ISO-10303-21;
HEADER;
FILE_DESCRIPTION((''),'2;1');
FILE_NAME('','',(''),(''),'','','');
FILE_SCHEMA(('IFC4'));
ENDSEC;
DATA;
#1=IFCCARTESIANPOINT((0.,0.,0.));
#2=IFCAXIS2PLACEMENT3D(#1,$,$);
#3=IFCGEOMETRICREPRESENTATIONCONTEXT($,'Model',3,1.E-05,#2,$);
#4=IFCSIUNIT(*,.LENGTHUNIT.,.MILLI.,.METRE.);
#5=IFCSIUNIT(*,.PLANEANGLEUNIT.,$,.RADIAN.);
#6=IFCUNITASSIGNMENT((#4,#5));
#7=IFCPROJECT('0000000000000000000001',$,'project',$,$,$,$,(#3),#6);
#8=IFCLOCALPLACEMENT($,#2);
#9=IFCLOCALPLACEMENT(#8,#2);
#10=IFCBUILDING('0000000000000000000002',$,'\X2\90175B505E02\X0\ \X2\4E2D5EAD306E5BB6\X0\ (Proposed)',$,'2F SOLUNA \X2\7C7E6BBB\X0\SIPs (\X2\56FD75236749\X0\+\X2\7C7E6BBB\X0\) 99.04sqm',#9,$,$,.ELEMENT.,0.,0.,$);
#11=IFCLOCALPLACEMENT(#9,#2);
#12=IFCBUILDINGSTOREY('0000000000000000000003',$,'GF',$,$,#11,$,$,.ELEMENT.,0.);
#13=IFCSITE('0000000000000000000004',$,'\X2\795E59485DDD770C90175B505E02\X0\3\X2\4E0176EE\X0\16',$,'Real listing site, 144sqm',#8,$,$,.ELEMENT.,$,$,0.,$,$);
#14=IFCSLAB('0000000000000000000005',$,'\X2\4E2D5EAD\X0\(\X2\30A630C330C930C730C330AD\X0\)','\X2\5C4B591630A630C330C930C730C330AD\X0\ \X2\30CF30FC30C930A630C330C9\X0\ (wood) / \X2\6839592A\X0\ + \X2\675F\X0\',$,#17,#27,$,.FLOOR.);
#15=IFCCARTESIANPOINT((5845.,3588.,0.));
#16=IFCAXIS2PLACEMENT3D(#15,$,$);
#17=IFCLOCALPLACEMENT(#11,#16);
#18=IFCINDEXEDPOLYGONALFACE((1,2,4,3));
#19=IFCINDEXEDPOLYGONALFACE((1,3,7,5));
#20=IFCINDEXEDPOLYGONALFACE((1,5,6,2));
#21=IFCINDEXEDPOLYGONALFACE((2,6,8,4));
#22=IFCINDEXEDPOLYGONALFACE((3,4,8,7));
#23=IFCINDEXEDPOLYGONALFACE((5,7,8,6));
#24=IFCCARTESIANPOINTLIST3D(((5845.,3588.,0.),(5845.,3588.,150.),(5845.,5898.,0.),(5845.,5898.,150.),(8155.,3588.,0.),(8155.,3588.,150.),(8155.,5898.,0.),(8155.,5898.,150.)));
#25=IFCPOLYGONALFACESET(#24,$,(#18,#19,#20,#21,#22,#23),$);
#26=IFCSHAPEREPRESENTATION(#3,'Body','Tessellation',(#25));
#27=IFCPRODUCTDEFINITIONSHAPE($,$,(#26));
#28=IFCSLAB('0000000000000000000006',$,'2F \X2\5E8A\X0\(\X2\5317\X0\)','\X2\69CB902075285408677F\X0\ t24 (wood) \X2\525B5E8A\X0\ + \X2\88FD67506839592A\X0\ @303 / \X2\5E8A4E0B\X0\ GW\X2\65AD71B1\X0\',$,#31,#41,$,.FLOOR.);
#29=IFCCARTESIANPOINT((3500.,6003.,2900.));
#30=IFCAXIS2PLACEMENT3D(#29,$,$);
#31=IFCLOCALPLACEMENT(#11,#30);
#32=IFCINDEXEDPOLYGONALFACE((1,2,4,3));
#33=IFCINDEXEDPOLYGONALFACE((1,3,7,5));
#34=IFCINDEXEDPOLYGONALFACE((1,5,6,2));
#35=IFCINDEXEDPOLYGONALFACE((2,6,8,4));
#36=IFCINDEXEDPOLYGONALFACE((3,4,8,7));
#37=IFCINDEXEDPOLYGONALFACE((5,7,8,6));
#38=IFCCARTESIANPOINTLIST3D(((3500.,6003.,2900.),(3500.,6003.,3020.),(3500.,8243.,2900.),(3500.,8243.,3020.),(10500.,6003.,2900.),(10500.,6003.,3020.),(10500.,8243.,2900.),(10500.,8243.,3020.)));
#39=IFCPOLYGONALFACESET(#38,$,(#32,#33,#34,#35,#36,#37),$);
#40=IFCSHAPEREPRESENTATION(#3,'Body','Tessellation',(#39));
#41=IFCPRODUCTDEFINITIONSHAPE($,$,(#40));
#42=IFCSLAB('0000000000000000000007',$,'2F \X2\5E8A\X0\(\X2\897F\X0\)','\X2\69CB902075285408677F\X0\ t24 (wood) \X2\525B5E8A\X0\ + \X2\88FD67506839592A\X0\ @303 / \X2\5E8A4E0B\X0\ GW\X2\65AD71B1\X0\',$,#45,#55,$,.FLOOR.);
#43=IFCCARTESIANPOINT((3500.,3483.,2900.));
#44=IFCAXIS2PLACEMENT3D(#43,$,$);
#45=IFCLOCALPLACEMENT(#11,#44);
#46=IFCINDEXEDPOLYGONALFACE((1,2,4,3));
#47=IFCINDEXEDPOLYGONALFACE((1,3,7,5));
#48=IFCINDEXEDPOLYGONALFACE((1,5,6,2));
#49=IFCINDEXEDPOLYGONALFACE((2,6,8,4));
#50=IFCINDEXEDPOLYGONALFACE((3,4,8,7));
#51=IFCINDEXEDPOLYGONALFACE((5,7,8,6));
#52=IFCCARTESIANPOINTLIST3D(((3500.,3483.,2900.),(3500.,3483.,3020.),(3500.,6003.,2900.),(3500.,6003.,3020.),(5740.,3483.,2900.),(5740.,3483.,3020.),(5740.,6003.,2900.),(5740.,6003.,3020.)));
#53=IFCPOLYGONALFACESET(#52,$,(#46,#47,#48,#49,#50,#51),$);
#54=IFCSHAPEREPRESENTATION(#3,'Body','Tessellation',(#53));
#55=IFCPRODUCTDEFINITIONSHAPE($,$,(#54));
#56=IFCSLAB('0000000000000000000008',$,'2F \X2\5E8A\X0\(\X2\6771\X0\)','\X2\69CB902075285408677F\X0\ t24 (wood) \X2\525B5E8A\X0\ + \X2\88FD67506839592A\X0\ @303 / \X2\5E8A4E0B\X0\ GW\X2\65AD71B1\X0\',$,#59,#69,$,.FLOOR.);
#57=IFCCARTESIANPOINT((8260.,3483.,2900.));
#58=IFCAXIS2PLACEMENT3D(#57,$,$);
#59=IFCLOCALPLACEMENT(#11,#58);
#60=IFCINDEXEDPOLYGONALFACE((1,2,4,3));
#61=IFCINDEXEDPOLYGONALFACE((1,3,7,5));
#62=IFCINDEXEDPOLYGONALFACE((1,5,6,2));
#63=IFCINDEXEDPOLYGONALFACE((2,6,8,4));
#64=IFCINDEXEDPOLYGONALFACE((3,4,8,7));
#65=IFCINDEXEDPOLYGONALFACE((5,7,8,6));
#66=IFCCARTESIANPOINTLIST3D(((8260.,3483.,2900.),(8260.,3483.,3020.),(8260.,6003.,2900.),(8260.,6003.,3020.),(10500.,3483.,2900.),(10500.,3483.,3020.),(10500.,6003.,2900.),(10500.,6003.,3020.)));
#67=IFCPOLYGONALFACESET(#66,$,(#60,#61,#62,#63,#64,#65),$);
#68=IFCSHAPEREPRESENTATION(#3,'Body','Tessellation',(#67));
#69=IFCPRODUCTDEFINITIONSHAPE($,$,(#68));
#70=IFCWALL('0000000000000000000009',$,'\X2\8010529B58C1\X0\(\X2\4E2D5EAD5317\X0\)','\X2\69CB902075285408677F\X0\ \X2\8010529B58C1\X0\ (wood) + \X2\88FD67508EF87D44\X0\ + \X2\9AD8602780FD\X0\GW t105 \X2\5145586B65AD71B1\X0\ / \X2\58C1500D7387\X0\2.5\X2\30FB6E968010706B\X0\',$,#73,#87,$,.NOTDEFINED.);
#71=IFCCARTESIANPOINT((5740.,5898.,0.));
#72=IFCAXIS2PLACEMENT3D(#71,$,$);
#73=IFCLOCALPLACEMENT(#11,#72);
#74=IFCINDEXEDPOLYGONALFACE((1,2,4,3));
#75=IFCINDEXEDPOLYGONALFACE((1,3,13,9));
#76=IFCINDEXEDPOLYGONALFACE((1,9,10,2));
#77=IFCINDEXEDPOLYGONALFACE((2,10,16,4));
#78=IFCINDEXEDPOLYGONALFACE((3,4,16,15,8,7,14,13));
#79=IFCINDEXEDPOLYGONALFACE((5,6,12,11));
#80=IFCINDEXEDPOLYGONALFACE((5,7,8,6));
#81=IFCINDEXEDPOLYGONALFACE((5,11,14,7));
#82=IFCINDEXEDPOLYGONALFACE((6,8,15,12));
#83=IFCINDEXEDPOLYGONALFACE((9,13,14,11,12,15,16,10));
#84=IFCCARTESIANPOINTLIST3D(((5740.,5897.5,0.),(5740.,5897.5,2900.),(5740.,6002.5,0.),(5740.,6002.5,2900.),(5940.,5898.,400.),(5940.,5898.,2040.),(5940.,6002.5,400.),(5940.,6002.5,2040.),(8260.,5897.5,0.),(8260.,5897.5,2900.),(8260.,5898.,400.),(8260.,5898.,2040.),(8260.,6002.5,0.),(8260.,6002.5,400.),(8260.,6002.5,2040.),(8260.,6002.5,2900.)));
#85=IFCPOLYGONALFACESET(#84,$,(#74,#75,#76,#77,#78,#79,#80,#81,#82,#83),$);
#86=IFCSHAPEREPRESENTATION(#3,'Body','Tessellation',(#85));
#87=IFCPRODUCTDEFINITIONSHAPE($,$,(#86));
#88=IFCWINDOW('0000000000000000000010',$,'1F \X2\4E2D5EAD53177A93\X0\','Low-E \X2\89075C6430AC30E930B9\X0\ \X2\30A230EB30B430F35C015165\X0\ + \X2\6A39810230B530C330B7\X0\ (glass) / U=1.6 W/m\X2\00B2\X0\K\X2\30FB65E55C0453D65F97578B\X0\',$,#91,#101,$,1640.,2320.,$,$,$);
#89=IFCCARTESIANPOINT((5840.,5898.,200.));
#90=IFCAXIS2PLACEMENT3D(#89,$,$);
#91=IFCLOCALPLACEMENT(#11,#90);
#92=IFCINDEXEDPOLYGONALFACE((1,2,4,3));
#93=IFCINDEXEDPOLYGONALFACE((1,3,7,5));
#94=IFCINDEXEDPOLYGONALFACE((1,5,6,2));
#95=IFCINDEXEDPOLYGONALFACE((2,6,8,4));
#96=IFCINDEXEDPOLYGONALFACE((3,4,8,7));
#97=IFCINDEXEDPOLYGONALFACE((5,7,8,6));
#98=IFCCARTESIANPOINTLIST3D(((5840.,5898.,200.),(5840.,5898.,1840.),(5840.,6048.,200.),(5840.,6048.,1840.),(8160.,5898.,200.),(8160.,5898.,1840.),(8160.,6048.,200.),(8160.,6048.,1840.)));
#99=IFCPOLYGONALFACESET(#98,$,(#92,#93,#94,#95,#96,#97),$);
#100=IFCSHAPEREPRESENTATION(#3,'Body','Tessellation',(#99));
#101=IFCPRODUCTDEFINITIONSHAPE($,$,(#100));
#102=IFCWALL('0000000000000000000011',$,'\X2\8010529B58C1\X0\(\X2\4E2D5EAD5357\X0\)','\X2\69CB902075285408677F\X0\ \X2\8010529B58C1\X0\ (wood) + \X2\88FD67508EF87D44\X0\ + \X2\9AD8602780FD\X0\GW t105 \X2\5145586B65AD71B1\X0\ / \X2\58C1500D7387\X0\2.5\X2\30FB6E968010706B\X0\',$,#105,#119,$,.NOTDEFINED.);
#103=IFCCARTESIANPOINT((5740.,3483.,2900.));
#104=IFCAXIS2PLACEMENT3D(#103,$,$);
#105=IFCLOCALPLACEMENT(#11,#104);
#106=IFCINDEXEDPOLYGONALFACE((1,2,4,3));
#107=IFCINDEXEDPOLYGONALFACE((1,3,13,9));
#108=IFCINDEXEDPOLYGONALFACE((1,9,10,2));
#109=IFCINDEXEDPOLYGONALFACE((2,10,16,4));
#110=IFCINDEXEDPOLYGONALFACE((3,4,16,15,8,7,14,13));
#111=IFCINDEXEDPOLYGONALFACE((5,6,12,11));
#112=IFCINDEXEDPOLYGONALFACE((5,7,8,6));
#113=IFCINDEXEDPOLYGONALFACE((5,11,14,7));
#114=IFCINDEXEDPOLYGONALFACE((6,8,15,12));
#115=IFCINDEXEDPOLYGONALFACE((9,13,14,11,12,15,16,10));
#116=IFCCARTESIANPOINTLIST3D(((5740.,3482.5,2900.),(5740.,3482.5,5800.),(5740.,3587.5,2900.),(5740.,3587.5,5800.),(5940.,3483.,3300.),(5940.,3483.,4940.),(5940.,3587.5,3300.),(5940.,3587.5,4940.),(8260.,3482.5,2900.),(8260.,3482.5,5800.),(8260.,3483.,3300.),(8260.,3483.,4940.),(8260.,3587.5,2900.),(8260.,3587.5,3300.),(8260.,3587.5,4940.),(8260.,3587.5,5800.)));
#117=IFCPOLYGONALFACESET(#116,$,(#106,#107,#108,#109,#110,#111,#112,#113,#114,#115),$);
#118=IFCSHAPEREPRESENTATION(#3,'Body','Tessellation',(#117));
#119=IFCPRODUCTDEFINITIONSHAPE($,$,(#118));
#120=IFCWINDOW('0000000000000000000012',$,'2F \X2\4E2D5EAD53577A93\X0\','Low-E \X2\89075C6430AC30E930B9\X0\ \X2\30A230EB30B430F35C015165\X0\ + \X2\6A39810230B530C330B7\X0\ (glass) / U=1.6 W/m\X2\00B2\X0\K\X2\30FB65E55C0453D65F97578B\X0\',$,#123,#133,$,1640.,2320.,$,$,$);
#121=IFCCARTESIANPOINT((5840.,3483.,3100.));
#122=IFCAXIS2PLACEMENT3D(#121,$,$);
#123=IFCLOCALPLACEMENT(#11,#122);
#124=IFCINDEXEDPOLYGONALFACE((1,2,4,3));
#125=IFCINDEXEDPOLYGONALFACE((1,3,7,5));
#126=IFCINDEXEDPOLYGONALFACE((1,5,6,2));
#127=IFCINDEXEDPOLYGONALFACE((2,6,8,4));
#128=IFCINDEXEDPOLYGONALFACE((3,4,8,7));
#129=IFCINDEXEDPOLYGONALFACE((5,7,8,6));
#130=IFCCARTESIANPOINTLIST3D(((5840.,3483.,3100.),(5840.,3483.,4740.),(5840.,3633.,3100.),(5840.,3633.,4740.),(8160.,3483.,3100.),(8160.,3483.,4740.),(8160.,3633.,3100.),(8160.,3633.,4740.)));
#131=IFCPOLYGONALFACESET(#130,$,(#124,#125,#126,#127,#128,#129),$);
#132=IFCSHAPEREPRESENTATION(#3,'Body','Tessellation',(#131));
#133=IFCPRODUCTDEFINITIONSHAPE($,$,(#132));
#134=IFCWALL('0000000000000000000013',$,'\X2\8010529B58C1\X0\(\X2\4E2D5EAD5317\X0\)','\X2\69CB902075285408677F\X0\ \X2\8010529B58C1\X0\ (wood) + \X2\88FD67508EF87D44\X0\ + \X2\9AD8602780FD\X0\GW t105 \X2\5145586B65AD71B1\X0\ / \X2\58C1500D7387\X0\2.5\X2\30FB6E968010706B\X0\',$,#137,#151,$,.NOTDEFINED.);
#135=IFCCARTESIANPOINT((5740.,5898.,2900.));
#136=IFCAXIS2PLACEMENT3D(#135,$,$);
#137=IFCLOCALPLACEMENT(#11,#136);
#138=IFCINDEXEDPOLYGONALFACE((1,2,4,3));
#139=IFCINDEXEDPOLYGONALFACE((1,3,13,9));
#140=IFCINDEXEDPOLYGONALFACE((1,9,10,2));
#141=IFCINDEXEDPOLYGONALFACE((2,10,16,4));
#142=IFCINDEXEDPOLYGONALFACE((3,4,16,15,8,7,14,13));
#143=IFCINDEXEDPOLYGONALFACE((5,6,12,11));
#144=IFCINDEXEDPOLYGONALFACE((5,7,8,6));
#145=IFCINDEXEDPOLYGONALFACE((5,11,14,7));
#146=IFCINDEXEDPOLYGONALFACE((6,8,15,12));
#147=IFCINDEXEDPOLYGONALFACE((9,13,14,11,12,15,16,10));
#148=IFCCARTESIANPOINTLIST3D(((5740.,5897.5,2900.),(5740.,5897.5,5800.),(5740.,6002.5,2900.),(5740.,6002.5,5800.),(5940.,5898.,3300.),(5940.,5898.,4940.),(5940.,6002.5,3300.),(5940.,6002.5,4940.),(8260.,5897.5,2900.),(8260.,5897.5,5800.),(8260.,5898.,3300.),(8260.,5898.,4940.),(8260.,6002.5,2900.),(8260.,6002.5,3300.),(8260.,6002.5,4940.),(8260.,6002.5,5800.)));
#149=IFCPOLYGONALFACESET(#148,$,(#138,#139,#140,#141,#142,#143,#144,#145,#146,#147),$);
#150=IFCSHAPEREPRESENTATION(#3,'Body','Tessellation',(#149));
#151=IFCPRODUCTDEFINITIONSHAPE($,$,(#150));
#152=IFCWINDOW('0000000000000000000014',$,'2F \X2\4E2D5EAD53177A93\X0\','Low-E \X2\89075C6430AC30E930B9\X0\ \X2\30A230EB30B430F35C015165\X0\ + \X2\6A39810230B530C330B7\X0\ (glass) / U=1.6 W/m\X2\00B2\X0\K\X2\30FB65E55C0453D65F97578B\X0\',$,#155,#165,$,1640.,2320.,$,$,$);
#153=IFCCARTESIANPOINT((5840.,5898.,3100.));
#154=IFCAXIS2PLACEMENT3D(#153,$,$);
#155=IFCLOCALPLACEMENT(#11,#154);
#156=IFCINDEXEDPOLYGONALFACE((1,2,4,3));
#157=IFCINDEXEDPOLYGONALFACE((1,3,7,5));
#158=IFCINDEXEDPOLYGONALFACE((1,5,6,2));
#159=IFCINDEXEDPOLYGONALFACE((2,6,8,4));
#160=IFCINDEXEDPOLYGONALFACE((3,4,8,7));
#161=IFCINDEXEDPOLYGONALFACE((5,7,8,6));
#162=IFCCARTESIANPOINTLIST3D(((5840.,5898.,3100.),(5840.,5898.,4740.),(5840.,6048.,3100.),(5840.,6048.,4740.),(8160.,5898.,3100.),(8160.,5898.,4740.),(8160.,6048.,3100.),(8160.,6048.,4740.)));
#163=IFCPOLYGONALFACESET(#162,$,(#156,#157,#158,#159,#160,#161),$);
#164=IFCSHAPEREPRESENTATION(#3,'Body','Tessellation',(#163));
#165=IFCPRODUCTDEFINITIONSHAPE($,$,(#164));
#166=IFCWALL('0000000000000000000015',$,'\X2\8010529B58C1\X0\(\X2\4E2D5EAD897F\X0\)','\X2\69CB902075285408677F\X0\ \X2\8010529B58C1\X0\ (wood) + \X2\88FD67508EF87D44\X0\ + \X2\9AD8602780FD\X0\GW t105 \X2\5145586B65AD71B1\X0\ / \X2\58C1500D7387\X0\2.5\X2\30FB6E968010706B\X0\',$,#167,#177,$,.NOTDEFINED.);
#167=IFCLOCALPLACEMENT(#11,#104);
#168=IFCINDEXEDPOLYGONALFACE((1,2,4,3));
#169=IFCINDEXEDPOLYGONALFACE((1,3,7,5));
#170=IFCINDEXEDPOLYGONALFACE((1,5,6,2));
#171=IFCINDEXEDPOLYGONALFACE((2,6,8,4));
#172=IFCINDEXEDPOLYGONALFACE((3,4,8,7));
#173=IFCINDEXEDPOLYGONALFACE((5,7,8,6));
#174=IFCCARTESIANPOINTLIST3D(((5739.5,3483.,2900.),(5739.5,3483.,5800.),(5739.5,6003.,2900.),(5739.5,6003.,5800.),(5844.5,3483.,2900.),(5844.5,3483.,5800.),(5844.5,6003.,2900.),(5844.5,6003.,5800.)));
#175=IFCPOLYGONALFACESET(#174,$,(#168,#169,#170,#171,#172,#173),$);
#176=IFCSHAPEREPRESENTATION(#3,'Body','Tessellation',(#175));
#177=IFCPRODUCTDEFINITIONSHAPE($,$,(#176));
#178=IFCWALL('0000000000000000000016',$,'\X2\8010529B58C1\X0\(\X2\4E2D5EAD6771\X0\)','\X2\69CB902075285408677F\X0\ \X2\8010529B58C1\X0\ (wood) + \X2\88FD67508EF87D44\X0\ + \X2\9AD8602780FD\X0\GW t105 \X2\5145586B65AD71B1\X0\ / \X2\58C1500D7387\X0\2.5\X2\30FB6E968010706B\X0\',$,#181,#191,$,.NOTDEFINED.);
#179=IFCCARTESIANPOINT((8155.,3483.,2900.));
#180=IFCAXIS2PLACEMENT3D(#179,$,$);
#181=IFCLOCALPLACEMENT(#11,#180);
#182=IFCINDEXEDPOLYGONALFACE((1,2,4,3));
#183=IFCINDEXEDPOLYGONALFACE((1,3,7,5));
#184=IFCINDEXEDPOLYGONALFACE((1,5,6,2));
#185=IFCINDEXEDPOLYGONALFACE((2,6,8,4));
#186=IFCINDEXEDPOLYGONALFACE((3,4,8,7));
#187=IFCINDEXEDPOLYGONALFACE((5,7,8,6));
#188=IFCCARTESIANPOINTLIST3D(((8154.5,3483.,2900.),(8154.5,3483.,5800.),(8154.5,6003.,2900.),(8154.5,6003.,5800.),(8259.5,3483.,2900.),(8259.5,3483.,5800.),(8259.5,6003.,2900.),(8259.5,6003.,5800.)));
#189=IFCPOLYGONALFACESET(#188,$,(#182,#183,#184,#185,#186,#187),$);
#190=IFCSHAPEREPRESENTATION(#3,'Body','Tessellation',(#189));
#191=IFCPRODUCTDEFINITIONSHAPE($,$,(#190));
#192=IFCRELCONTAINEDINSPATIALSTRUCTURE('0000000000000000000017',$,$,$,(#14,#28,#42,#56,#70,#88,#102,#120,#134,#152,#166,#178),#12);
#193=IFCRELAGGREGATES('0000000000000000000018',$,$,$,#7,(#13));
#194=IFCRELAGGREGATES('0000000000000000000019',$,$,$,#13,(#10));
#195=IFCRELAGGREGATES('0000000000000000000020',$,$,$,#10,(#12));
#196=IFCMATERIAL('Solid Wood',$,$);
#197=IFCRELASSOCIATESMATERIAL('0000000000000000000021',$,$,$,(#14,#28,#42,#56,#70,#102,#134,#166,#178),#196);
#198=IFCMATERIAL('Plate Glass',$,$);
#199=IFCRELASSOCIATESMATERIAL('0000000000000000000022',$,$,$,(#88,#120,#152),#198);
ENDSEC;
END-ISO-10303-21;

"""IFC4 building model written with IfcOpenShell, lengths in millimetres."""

from ifc_helpers import new_model, si_unit, frame, frame_2d, origin, place, context, project, spatial, rectangle, extrude, material, element, fill, save


model = new_model("IFC4")

# Units and contexts
model_context = context("Model", 3, precision=1e-05, world=origin())
ifc_project = project(units=[si_unit("LENGTHUNIT", "METRE", prefix="MILLI"), si_unit("PLANEANGLEUNIT", "RADIAN")], contexts=[model_context])

# Site, building, storey
site_placement = place(None, origin())
site = spatial("IfcSite", under=ifc_project, at=site_placement, Name="神奈川県逗子市3丁目16", ObjectType="Real listing site, 144sqm", CompositionType="ELEMENT", RefElevation=0.0)
building_placement = place(site_placement, origin())
building = spatial("IfcBuilding", under=site, at=building_placement, Name="逗子市 中庭の家 (Proposed)", ObjectType="2F SOLUNA 籾殻SIPs (国産杉+籾殻) 99.04sqm", CompositionType="ELEMENT", ElevationOfRefHeight=0.0, ElevationOfTerrain=0.0)
storey_placement = place(building_placement, origin())
storey = spatial("IfcBuildingStorey", under=building, at=storey_placement, Name="GF", CompositionType="ELEMENT", Elevation=0.0)

# Slabs
ifc_material_1 = material(Name="Solid Wood")
slab_1_placement = place(storey_placement, frame((5845.0, 3588.0, 0.0)))
element("IfcSlab", 1, at=slab_1_placement, inside=storey, material=ifc_material_1, Name="中庭(ウッドデッキ)", Description="屋外ウッドデッキ ハードウッド (wood) / 根太 + 束", PredefinedType="FLOOR", context=model_context, shape_type="SweptSolid", body=[
    extrude(rectangle(XDim=2310.0, YDim=2310.0, at=frame_2d((1155.0, 1155.0))), frame((5845.0, 3588.0, 0.0)), (0.0, 0.0, 1.0), 150.0),
])
slab_2_placement = place(storey_placement, frame((3500.0, 6003.0, 2900.0)))
element("IfcSlab", 2, at=slab_2_placement, inside=storey, material=ifc_material_1, Name="2F 床(北)", Description="構造用合板 t24 (wood) 剛床 + 製材根太 @303 / 床下 GW断熱", PredefinedType="FLOOR", context=model_context, shape_type="SweptSolid", body=[
    extrude(rectangle(XDim=7000.0, YDim=2240.0, at=frame_2d((3500.0, 1120.0))), frame((3500.0, 6003.0, 2900.0)), (0.0, 0.0, 1.0), 120.0),
])
slab_3_placement = place(storey_placement, frame((3500.0, 3483.0, 2900.0)))
element("IfcSlab", 3, at=slab_3_placement, inside=storey, material=ifc_material_1, Name="2F 床(西)", Description="構造用合板 t24 (wood) 剛床 + 製材根太 @303 / 床下 GW断熱", PredefinedType="FLOOR", context=model_context, shape_type="SweptSolid", body=[
    extrude(rectangle(XDim=2240.0, YDim=2520.0, at=frame_2d((1120.0, 1260.0))), frame((3500.0, 3483.0, 2900.0)), (0.0, 0.0, 1.0), 120.0),
])
slab_4_placement = place(storey_placement, frame((8260.0, 3483.0, 2900.0)))
element("IfcSlab", 4, at=slab_4_placement, inside=storey, material=ifc_material_1, Name="2F 床(東)", Description="構造用合板 t24 (wood) 剛床 + 製材根太 @303 / 床下 GW断熱", PredefinedType="FLOOR", context=model_context, shape_type="SweptSolid", body=[
    extrude(rectangle(XDim=2240.0, YDim=2520.0, at=frame_2d((1120.0, 1260.0))), frame((8260.0, 3483.0, 2900.0)), (0.0, 0.0, 1.0), 120.0),
])

# Wall, opening, window
wall_1_placement = place(storey_placement, frame((5740.0, 5898.0, 0.0)))
wall_1 = element("IfcWall", 5, at=wall_1_placement, inside=storey, material=ifc_material_1, Name="耐力壁(中庭北)", Description="構造用合板 耐力壁 (wood) + 製材軸組 + 高性能GW t105 充填断熱 / 壁倍率2.5・準耐火", PredefinedType="NOTDEFINED", context=model_context, shape_type="SweptSolid", body=[
    extrude(rectangle(XDim=2520.0, YDim=105.0, at=frame_2d((1260.0, 52.0))), frame((5740.0, 5898.0, 0.0)), (0.0, 0.0, 1.0), 2900.0),
])
opening_1_placement = place(storey_placement, frame((5840.0, 5898.0, 200.0)))
opening_1 = element("IfcOpeningElement", 6, at=opening_1_placement, cuts=wall_1, PredefinedType="NOTDEFINED", context=model_context, shape_type="SweptSolid", body=[
    extrude(rectangle(XDim=2320.0, YDim=150.0, at=frame_2d((1160.0, 75.0))), frame((5840.0, 5898.0, 200.0)), (0.0, 0.0, 1.0), 1640.0),
])
ifc_material_2 = material(Name="Plate Glass")
window_1_placement = place(storey_placement, frame((5840.0, 5898.0, 200.0)))
window_1 = element("IfcWindow", 7, at=window_1_placement, inside=storey, material=ifc_material_2, Name="1F 中庭北窓", Description="Low-E 複層ガラス アルゴン封入 + 樹脂サッシ (glass) / U=1.6 W/m²K・日射取得型", OverallHeight=1640.0, OverallWidth=2320.0, context=model_context, shape_type="SweptSolid", body=[
    extrude(rectangle(XDim=2320.0, YDim=150.0, at=frame_2d((1160.0, 75.0))), frame((5840.0, 5898.0, 200.0)), (0.0, 0.0, 1.0), 1640.0),
])
fill(opening_1, window_1)

# Walls, openings, windows
wall_2_placement = place(storey_placement, frame((5740.0, 3483.0, 2900.0)))
wall_2 = element("IfcWall", 8, at=wall_2_placement, inside=storey, material=ifc_material_1, Name="耐力壁(中庭南)", Description="構造用合板 耐力壁 (wood) + 製材軸組 + 高性能GW t105 充填断熱 / 壁倍率2.5・準耐火", PredefinedType="NOTDEFINED", context=model_context, shape_type="SweptSolid", body=[
    extrude(rectangle(XDim=2520.0, YDim=105.0, at=frame_2d((1260.0, 52.0))), frame((5740.0, 3483.0, 2900.0)), (0.0, 0.0, 1.0), 2900.0),
])
opening_2_placement = place(storey_placement, frame((5840.0, 3483.0, 3100.0)))
opening_2 = element("IfcOpeningElement", 9, at=opening_2_placement, cuts=wall_2, PredefinedType="NOTDEFINED", context=model_context, shape_type="SweptSolid", body=[
    extrude(rectangle(XDim=2320.0, YDim=150.0, at=frame_2d((1160.0, 75.0))), frame((5840.0, 3483.0, 3100.0)), (0.0, 0.0, 1.0), 1640.0),
])
window_2_placement = place(storey_placement, frame((5840.0, 3483.0, 3100.0)))
window_2 = element("IfcWindow", 10, at=window_2_placement, inside=storey, material=ifc_material_2, Name="2F 中庭南窓", Description="Low-E 複層ガラス アルゴン封入 + 樹脂サッシ (glass) / U=1.6 W/m²K・日射取得型", OverallHeight=1640.0, OverallWidth=2320.0, context=model_context, shape_type="SweptSolid", body=[
    extrude(rectangle(XDim=2320.0, YDim=150.0, at=frame_2d((1160.0, 75.0))), frame((5840.0, 3483.0, 3100.0)), (0.0, 0.0, 1.0), 1640.0),
])
fill(opening_2, window_2)
wall_3_placement = place(storey_placement, frame((5740.0, 5898.0, 2900.0)))
wall_3 = element("IfcWall", 11, at=wall_3_placement, inside=storey, material=ifc_material_1, Name="耐力壁(中庭北)", Description="構造用合板 耐力壁 (wood) + 製材軸組 + 高性能GW t105 充填断熱 / 壁倍率2.5・準耐火", PredefinedType="NOTDEFINED", context=model_context, shape_type="SweptSolid", body=[
    extrude(rectangle(XDim=2520.0, YDim=105.0, at=frame_2d((1260.0, 52.0))), frame((5740.0, 5898.0, 2900.0)), (0.0, 0.0, 1.0), 2900.0),
])
opening_3_placement = place(storey_placement, frame((5840.0, 5898.0, 3100.0)))
opening_3 = element("IfcOpeningElement", 12, at=opening_3_placement, cuts=wall_3, PredefinedType="NOTDEFINED", context=model_context, shape_type="SweptSolid", body=[
    extrude(rectangle(XDim=2320.0, YDim=150.0, at=frame_2d((1160.0, 75.0))), frame((5840.0, 5898.0, 3100.0)), (0.0, 0.0, 1.0), 1640.0),
])
window_3_placement = place(storey_placement, frame((5840.0, 5898.0, 3100.0)))
window_3 = element("IfcWindow", 13, at=window_3_placement, inside=storey, material=ifc_material_2, Name="2F 中庭北窓", Description="Low-E 複層ガラス アルゴン封入 + 樹脂サッシ (glass) / U=1.6 W/m²K・日射取得型", OverallHeight=1640.0, OverallWidth=2320.0, context=model_context, shape_type="SweptSolid", body=[
    extrude(rectangle(XDim=2320.0, YDim=150.0, at=frame_2d((1160.0, 75.0))), frame((5840.0, 5898.0, 3100.0)), (0.0, 0.0, 1.0), 1640.0),
])
fill(opening_3, window_3)

# Walls
wall_4_placement = place(storey_placement, frame((5740.0, 3483.0, 2900.0)))
element("IfcWall", 14, at=wall_4_placement, inside=storey, material=ifc_material_1, Name="耐力壁(中庭西)", Description="構造用合板 耐力壁 (wood) + 製材軸組 + 高性能GW t105 充填断熱 / 壁倍率2.5・準耐火", PredefinedType="NOTDEFINED", context=model_context, shape_type="SweptSolid", body=[
    extrude(rectangle(XDim=105.0, YDim=2520.0, at=frame_2d((52.0, 1260.0))), frame((5740.0, 3483.0, 2900.0)), (0.0, 0.0, 1.0), 2900.0),
])
wall_5_placement = place(storey_placement, frame((8155.0, 3483.0, 2900.0)))
element("IfcWall", 15, at=wall_5_placement, inside=storey, material=ifc_material_1, Name="耐力壁(中庭東)", Description="構造用合板 耐力壁 (wood) + 製材軸組 + 高性能GW t105 充填断熱 / 壁倍率2.5・準耐火", PredefinedType="NOTDEFINED", context=model_context, shape_type="SweptSolid", body=[
    extrude(rectangle(XDim=105.0, YDim=2520.0, at=frame_2d((52.0, 1260.0))), frame((8155.0, 3483.0, 2900.0)), (0.0, 0.0, 1.0), 2900.0),
])

save(model, "model.ifc")
